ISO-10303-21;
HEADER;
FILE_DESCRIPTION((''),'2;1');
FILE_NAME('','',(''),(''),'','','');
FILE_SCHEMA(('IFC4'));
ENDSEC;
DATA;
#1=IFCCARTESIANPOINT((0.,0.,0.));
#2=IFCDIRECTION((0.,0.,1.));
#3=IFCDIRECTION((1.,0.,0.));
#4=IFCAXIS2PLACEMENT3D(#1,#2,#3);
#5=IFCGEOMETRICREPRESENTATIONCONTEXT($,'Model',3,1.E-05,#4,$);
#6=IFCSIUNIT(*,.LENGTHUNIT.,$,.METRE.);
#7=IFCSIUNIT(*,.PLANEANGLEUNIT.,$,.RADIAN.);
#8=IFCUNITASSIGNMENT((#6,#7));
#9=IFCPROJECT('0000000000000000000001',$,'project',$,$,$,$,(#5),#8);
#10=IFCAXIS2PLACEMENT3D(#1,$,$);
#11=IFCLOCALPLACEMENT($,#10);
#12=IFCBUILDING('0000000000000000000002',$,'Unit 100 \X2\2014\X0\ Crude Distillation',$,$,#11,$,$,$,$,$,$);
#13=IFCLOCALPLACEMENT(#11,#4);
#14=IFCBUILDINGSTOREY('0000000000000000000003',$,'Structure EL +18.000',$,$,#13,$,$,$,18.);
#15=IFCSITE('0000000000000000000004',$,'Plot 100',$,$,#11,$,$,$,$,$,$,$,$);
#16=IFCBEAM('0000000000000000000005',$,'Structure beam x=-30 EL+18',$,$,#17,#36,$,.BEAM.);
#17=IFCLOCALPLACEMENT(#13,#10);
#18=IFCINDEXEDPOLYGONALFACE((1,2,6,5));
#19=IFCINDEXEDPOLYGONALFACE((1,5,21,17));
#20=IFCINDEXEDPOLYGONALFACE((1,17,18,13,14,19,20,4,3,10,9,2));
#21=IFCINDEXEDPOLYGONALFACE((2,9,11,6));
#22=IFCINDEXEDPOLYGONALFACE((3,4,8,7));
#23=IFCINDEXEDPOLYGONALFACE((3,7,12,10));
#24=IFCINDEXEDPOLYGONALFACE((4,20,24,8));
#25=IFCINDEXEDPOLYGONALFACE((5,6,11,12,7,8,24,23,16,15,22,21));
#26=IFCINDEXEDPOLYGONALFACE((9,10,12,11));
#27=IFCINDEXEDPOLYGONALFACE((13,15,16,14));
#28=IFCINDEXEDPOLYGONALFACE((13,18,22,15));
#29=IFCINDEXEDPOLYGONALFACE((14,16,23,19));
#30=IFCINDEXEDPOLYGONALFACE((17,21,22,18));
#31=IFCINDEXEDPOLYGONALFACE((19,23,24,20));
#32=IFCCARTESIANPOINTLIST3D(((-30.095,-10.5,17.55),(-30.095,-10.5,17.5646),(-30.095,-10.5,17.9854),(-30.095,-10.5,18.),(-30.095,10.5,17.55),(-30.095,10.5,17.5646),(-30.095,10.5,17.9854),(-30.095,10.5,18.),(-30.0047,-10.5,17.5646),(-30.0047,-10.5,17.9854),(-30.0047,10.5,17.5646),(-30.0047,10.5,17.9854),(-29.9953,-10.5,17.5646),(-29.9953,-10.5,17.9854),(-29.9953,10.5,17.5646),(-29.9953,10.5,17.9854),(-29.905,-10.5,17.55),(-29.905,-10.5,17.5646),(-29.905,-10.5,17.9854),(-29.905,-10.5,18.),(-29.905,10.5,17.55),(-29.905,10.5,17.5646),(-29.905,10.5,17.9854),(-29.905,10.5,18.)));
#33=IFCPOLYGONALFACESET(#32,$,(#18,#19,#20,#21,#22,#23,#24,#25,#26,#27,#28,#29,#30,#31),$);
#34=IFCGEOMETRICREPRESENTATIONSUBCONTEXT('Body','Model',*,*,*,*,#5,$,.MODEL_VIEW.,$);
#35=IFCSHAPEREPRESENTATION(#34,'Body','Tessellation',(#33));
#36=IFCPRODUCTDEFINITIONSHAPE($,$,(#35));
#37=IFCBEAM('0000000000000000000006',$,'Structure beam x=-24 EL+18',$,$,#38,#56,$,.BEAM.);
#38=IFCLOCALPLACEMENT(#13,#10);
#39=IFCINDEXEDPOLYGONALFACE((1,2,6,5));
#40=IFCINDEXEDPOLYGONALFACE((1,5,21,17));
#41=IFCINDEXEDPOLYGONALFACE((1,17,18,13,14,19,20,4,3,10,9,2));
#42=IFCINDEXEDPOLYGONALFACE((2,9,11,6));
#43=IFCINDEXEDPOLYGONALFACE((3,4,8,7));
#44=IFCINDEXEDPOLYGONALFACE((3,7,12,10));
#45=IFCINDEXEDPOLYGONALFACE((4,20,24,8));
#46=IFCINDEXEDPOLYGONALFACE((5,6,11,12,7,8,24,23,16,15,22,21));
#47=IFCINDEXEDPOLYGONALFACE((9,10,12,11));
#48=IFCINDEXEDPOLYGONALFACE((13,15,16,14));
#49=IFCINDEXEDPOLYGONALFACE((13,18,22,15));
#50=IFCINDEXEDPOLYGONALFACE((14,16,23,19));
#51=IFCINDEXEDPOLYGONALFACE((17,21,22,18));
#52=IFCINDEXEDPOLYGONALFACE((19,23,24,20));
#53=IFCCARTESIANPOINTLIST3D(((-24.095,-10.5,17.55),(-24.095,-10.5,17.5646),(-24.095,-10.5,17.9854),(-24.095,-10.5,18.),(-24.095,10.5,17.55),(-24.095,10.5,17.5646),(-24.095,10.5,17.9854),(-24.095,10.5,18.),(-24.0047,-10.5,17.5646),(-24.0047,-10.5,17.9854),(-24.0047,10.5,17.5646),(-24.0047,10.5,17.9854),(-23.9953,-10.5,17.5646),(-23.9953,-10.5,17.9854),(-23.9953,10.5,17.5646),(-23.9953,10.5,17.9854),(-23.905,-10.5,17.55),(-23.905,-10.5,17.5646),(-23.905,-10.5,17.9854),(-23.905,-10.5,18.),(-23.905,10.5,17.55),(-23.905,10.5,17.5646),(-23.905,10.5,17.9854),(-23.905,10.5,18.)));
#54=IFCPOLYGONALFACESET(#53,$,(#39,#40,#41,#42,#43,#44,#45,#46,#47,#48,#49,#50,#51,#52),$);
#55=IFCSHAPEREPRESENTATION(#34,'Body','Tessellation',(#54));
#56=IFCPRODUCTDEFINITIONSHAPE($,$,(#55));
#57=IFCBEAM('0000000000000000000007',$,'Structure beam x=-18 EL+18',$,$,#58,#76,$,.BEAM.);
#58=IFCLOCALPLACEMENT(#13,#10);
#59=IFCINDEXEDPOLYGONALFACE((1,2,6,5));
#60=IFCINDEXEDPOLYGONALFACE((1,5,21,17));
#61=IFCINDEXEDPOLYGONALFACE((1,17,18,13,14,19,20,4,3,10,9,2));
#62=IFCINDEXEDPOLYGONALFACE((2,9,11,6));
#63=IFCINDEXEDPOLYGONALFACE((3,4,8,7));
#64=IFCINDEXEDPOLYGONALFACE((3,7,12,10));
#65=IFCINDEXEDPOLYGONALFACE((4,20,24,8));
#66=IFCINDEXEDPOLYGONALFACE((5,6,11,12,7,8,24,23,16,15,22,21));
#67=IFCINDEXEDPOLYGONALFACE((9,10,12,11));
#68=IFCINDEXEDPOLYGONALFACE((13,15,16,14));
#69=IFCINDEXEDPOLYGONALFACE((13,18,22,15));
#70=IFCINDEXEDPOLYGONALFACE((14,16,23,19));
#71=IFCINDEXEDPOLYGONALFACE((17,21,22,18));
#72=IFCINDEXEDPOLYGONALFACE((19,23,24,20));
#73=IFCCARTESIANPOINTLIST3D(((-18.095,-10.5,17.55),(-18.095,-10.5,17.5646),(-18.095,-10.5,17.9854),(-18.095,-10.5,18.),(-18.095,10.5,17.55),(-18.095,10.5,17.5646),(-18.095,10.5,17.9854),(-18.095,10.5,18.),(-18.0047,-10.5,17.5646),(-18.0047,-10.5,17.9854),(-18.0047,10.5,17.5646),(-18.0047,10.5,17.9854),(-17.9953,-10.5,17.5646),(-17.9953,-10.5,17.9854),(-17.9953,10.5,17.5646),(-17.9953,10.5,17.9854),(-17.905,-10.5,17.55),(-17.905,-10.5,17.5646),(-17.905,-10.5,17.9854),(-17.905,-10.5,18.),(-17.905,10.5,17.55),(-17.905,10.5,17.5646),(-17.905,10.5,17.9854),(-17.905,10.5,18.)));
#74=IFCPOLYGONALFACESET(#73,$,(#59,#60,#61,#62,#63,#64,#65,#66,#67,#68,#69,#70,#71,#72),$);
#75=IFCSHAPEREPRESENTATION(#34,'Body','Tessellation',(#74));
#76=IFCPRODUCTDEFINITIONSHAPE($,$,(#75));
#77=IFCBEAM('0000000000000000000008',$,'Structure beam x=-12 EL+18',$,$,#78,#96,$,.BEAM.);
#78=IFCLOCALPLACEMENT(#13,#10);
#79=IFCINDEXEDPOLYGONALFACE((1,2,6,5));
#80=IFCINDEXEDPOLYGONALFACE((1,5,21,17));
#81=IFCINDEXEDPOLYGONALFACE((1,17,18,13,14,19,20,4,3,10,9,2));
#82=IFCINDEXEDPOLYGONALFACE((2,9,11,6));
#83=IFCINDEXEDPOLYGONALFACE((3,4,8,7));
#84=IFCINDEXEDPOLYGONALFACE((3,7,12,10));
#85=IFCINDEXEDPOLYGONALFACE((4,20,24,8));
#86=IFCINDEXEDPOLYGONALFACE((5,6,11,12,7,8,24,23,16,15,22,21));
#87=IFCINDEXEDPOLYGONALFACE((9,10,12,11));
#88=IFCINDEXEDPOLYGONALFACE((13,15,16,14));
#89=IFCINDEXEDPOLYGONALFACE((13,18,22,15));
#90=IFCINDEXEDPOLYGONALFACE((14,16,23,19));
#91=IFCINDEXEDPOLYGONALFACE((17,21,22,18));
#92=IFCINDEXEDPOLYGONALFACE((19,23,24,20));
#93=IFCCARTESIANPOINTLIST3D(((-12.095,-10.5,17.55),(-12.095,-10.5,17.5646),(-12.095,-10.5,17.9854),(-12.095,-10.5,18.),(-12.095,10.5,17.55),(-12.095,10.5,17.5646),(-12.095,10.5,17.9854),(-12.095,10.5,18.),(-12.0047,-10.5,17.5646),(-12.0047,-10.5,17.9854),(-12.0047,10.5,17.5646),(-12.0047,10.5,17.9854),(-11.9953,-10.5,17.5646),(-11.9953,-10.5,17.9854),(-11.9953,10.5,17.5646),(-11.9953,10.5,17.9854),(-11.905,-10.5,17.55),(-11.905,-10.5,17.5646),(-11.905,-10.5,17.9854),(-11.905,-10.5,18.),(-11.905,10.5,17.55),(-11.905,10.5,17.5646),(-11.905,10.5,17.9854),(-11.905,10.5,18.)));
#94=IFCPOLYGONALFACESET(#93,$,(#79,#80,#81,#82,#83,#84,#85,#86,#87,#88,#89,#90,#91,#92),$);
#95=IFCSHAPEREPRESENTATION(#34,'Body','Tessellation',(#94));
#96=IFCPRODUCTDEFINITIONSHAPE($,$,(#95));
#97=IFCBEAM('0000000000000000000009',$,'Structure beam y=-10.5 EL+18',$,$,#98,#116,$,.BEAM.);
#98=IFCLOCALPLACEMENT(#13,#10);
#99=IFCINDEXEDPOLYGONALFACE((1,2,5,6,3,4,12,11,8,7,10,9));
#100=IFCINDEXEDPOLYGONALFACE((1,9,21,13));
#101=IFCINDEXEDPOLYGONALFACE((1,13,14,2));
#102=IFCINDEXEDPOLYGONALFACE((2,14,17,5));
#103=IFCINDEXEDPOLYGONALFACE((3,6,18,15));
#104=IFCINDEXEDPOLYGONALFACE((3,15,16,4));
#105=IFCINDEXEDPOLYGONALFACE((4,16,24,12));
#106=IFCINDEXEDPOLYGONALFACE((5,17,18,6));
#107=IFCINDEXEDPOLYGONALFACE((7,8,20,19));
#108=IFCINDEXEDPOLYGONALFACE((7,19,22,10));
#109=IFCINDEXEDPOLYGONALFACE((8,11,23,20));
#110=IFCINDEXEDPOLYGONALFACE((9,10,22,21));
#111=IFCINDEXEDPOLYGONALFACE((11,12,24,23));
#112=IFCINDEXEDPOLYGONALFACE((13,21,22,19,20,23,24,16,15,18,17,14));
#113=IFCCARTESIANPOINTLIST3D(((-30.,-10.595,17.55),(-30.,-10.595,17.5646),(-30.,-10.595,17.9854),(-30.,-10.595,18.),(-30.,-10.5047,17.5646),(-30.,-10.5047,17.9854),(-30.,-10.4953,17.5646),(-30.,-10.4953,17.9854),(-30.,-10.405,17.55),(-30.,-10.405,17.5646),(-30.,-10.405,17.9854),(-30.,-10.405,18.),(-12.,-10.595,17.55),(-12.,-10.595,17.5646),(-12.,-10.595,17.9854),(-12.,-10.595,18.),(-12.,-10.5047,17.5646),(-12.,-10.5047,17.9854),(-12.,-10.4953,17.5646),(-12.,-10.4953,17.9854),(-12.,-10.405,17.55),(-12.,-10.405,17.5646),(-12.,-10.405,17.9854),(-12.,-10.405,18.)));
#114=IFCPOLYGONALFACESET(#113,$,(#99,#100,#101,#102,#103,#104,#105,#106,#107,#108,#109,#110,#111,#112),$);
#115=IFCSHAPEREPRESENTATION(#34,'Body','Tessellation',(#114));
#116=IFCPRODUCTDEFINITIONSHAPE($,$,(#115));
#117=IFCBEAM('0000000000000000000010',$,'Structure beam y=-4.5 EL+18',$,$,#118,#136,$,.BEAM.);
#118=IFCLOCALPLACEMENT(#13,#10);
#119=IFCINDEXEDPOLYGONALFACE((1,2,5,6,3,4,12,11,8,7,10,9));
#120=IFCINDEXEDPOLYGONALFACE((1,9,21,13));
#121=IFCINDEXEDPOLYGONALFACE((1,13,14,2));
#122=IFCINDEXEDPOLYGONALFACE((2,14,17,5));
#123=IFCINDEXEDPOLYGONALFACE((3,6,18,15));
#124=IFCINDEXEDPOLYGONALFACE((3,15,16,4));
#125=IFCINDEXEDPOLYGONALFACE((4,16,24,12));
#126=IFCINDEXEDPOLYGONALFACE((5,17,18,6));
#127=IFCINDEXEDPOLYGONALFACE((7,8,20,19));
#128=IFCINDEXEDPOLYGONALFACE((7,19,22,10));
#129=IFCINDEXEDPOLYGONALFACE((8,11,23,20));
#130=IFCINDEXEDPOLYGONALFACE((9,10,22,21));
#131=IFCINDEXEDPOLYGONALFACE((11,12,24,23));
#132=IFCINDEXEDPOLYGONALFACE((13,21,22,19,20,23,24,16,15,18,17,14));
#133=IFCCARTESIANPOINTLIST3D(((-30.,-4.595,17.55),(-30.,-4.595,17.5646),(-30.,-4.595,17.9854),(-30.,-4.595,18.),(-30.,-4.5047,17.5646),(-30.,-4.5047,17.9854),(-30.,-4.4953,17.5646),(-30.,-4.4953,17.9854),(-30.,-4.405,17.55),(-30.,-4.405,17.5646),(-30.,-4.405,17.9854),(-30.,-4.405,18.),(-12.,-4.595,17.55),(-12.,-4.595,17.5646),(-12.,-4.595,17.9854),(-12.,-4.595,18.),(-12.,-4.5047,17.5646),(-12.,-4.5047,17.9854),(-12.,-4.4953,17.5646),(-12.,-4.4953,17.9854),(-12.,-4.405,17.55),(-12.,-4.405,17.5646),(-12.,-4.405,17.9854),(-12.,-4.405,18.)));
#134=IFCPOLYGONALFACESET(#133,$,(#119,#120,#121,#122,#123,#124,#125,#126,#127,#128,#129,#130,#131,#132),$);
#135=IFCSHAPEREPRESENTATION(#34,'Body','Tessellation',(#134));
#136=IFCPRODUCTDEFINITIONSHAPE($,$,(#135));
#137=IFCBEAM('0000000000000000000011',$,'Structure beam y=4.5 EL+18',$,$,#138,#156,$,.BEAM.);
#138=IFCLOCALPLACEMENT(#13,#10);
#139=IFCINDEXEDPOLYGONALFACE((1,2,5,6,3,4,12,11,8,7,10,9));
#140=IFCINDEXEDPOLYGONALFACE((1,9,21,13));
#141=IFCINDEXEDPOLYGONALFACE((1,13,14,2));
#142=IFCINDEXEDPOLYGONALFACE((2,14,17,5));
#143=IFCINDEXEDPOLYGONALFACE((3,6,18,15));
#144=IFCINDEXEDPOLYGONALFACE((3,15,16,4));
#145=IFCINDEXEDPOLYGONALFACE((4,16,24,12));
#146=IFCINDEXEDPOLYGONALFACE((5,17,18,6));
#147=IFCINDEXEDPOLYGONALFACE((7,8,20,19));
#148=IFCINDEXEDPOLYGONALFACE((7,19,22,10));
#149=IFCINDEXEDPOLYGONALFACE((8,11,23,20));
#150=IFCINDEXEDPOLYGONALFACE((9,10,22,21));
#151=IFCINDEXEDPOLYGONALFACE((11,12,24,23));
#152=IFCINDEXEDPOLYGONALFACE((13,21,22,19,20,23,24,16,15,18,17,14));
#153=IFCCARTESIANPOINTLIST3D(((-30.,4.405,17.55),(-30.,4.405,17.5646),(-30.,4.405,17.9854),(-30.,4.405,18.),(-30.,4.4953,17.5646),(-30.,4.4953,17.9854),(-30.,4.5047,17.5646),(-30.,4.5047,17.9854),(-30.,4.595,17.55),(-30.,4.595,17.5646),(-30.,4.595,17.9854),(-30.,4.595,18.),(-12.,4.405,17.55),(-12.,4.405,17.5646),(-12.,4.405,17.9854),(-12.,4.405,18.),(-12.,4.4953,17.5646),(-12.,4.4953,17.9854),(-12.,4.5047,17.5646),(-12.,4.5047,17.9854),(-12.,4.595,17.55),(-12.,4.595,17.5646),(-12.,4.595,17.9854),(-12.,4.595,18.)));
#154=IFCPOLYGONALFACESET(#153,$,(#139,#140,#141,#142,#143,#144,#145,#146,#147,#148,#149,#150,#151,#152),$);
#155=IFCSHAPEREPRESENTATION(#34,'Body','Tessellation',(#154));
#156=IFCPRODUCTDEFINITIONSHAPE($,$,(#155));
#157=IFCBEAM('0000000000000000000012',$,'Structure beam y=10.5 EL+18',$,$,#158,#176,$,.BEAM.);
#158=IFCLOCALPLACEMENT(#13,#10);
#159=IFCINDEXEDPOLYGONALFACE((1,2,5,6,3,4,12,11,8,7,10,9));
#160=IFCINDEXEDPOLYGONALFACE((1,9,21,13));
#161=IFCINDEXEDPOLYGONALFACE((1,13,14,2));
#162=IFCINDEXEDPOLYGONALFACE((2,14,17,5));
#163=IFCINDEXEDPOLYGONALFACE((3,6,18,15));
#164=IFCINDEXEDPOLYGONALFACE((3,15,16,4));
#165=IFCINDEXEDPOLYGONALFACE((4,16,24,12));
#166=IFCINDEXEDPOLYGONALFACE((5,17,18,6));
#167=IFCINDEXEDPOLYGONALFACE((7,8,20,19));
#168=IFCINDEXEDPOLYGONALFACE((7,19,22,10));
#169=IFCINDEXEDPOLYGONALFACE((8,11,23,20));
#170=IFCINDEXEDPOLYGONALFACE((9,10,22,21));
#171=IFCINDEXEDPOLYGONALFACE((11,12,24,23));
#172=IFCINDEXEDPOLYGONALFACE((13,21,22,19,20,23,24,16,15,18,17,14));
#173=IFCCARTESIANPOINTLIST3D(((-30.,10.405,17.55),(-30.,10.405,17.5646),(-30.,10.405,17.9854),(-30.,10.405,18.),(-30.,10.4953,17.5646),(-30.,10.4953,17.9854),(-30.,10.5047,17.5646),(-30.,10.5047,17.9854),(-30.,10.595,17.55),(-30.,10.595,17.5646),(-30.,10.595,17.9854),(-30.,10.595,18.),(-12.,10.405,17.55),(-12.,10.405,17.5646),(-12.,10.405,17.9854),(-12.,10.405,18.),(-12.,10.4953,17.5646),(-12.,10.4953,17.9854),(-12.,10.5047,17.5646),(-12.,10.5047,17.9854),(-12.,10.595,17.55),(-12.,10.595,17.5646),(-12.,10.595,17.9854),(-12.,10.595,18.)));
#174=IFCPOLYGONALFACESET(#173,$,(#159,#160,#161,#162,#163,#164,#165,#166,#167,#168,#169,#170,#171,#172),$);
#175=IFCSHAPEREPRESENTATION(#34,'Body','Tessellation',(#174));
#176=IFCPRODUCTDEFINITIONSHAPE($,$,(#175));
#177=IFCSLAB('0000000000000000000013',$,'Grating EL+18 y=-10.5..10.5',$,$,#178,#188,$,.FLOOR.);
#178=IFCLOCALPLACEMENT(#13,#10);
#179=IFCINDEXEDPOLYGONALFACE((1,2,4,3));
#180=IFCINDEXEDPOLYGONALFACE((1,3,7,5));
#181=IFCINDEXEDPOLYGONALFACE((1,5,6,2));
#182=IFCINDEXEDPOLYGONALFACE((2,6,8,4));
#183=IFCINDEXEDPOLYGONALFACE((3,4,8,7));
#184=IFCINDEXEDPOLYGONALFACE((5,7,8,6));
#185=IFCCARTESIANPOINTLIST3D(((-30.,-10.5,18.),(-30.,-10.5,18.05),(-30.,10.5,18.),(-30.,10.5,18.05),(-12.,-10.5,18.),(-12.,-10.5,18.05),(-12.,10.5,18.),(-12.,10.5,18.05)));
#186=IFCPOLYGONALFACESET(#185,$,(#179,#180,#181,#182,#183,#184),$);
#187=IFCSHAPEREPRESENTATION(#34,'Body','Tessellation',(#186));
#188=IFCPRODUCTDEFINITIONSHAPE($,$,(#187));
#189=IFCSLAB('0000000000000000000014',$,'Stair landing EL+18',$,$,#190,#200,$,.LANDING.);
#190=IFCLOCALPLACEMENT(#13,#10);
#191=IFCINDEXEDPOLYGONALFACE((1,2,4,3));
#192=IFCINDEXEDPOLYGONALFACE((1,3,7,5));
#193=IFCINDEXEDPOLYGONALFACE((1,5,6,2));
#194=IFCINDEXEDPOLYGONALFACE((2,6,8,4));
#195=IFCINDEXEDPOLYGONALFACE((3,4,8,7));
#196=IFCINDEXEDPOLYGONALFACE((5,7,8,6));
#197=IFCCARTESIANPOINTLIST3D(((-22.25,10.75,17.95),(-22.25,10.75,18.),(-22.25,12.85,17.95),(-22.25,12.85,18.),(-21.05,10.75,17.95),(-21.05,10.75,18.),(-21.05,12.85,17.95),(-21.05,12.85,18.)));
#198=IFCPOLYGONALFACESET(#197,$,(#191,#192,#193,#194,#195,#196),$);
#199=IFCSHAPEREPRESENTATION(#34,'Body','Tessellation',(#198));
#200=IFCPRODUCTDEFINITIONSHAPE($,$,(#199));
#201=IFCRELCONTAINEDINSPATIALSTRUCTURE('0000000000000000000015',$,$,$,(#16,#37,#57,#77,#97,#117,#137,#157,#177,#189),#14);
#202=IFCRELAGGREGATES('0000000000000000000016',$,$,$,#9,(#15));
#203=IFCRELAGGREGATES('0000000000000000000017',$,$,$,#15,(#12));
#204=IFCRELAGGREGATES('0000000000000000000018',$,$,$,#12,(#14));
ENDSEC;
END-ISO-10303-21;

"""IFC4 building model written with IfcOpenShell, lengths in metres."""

from ifc_helpers import new_model, si_unit, frame, origin, origin_with_axes, origin_2d, place, context, subcontext, project, spatial, rectangle, i_section, extrude, element, save


model = new_model("IFC4")

# Units and contexts
model_context = context("Model", 3, precision=1e-05, world=origin_with_axes())
body_context = subcontext(model_context, "Body", "Model", "MODEL_VIEW")
ifc_project = project(units=[si_unit("LENGTHUNIT", "METRE"), si_unit("PLANEANGLEUNIT", "RADIAN")], contexts=[model_context])

# Site, building, storey
placement = place(None, origin())
site = spatial("IfcSite", under=ifc_project, at=placement, Name="Plot 100")
building = spatial("IfcBuilding", under=site, at=placement, Name="Unit 100 — Crude Distillation")
storey_placement = place(placement, origin_with_axes())
storey = spatial("IfcBuildingStorey", under=building, at=storey_placement, Name="Structure EL +18.000", Elevation=18.0)

# Beams
beam_1_placement = place(storey_placement, origin_with_axes())
element("IfcBeam", 1, at=beam_1_placement, inside=storey, Name="Structure beam x=-30 EL+18", PredefinedType="BEAM", context=body_context, shape_type="SweptSolid", body=[
    extrude(i_section(OverallWidth=0.19, OverallDepth=0.45, WebThickness=0.0094, FlangeThickness=0.0146, at=origin_2d()), frame((-30.0, -10.5, 17.775), z_axis=(0.0, 1.0, 0.0), x_axis=(-1.0, 0.0, 0.0)), (0.0, 0.0, 1.0), 21.0),
])
beam_2_placement = place(storey_placement, origin_with_axes())
element("IfcBeam", 2, at=beam_2_placement, inside=storey, Name="Structure beam x=-24 EL+18", PredefinedType="BEAM", context=body_context, shape_type="SweptSolid", body=[
    extrude(i_section(OverallWidth=0.19, OverallDepth=0.45, WebThickness=0.0094, FlangeThickness=0.0146, at=origin_2d()), frame((-24.0, -10.5, 17.775), z_axis=(0.0, 1.0, 0.0), x_axis=(-1.0, 0.0, 0.0)), (0.0, 0.0, 1.0), 21.0),
])
beam_3_placement = place(storey_placement, origin_with_axes())
element("IfcBeam", 3, at=beam_3_placement, inside=storey, Name="Structure beam x=-18 EL+18", PredefinedType="BEAM", context=body_context, shape_type="SweptSolid", body=[
    extrude(i_section(OverallWidth=0.19, OverallDepth=0.45, WebThickness=0.0094, FlangeThickness=0.0146, at=origin_2d()), frame((-18.0, -10.5, 17.775), z_axis=(0.0, 1.0, 0.0), x_axis=(-1.0, 0.0, 0.0)), (0.0, 0.0, 1.0), 21.0),
])
beam_4_placement = place(storey_placement, origin_with_axes())
element("IfcBeam", 4, at=beam_4_placement, inside=storey, Name="Structure beam x=-12 EL+18", PredefinedType="BEAM", context=body_context, shape_type="SweptSolid", body=[
    extrude(i_section(OverallWidth=0.19, OverallDepth=0.45, WebThickness=0.0094, FlangeThickness=0.0146, at=origin_2d()), frame((-12.0, -10.5, 17.775), z_axis=(0.0, 1.0, 0.0), x_axis=(-1.0, 0.0, 0.0)), (0.0, 0.0, 1.0), 21.0),
])
beam_5_placement = place(storey_placement, origin_with_axes())
element("IfcBeam", 5, at=beam_5_placement, inside=storey, Name="Structure beam y=-10.5 EL+18", PredefinedType="BEAM", context=body_context, shape_type="SweptSolid", body=[
    extrude(i_section(OverallWidth=0.19, OverallDepth=0.45, WebThickness=0.0094, FlangeThickness=0.0146, at=origin_2d()), frame((-30.0, -10.5, 17.775), z_axis=(1.0, 0.0, 0.0), x_axis=(0.0, 1.0, 0.0)), (0.0, 0.0, 1.0), 18.0),
])
beam_6_placement = place(storey_placement, origin_with_axes())
element("IfcBeam", 6, at=beam_6_placement, inside=storey, Name="Structure beam y=-4.5 EL+18", PredefinedType="BEAM", context=body_context, shape_type="SweptSolid", body=[
    extrude(i_section(OverallWidth=0.19, OverallDepth=0.45, WebThickness=0.0094, FlangeThickness=0.0146, at=origin_2d()), frame((-30.0, -4.5, 17.775), z_axis=(1.0, 0.0, 0.0), x_axis=(0.0, 1.0, 0.0)), (0.0, 0.0, 1.0), 18.0),
])
beam_7_placement = place(storey_placement, origin_with_axes())
element("IfcBeam", 7, at=beam_7_placement, inside=storey, Name="Structure beam y=4.5 EL+18", PredefinedType="BEAM", context=body_context, shape_type="SweptSolid", body=[
    extrude(i_section(OverallWidth=0.19, OverallDepth=0.45, WebThickness=0.0094, FlangeThickness=0.0146, at=origin_2d()), frame((-30.0, 4.5, 17.775), z_axis=(1.0, 0.0, 0.0), x_axis=(0.0, 1.0, 0.0)), (0.0, 0.0, 1.0), 18.0),
])
beam_8_placement = place(storey_placement, origin_with_axes())
element("IfcBeam", 8, at=beam_8_placement, inside=storey, Name="Structure beam y=10.5 EL+18", PredefinedType="BEAM", context=body_context, shape_type="SweptSolid", body=[
    extrude(i_section(OverallWidth=0.19, OverallDepth=0.45, WebThickness=0.0094, FlangeThickness=0.0146, at=origin_2d()), frame((-30.0, 10.5, 17.775), z_axis=(1.0, 0.0, 0.0), x_axis=(0.0, 1.0, 0.0)), (0.0, 0.0, 1.0), 18.0),
])

# Slabs
slab_1_placement = place(storey_placement, origin_with_axes())
element("IfcSlab", 9, at=slab_1_placement, inside=storey, Name="Grating EL+18 y=-10.5..10.5", PredefinedType="FLOOR", context=body_context, shape_type="SweptSolid", body=[
    extrude(rectangle(XDim=18.0, YDim=21.0, at=origin_2d()), frame((-21.0, 0.0, 18.0), z_axis=(0.0, 0.0, 1.0), x_axis=(1.0, 0.0, 0.0)), (0.0, 0.0, 1.0), 0.05),
])
slab_2_placement = place(storey_placement, origin_with_axes())
element("IfcSlab", 10, at=slab_2_placement, inside=storey, Name="Stair landing EL+18", PredefinedType="LANDING", context=body_context, shape_type="SweptSolid", body=[
    extrude(rectangle(XDim=1.2, YDim=2.1, at=origin_2d()), frame((-21.65, 11.8, 17.95), z_axis=(0.0, 0.0, 1.0), x_axis=(1.0, 0.0, 0.0)), (0.0, 0.0, 1.0), 0.05),
])

save(model, "model.ifc")
